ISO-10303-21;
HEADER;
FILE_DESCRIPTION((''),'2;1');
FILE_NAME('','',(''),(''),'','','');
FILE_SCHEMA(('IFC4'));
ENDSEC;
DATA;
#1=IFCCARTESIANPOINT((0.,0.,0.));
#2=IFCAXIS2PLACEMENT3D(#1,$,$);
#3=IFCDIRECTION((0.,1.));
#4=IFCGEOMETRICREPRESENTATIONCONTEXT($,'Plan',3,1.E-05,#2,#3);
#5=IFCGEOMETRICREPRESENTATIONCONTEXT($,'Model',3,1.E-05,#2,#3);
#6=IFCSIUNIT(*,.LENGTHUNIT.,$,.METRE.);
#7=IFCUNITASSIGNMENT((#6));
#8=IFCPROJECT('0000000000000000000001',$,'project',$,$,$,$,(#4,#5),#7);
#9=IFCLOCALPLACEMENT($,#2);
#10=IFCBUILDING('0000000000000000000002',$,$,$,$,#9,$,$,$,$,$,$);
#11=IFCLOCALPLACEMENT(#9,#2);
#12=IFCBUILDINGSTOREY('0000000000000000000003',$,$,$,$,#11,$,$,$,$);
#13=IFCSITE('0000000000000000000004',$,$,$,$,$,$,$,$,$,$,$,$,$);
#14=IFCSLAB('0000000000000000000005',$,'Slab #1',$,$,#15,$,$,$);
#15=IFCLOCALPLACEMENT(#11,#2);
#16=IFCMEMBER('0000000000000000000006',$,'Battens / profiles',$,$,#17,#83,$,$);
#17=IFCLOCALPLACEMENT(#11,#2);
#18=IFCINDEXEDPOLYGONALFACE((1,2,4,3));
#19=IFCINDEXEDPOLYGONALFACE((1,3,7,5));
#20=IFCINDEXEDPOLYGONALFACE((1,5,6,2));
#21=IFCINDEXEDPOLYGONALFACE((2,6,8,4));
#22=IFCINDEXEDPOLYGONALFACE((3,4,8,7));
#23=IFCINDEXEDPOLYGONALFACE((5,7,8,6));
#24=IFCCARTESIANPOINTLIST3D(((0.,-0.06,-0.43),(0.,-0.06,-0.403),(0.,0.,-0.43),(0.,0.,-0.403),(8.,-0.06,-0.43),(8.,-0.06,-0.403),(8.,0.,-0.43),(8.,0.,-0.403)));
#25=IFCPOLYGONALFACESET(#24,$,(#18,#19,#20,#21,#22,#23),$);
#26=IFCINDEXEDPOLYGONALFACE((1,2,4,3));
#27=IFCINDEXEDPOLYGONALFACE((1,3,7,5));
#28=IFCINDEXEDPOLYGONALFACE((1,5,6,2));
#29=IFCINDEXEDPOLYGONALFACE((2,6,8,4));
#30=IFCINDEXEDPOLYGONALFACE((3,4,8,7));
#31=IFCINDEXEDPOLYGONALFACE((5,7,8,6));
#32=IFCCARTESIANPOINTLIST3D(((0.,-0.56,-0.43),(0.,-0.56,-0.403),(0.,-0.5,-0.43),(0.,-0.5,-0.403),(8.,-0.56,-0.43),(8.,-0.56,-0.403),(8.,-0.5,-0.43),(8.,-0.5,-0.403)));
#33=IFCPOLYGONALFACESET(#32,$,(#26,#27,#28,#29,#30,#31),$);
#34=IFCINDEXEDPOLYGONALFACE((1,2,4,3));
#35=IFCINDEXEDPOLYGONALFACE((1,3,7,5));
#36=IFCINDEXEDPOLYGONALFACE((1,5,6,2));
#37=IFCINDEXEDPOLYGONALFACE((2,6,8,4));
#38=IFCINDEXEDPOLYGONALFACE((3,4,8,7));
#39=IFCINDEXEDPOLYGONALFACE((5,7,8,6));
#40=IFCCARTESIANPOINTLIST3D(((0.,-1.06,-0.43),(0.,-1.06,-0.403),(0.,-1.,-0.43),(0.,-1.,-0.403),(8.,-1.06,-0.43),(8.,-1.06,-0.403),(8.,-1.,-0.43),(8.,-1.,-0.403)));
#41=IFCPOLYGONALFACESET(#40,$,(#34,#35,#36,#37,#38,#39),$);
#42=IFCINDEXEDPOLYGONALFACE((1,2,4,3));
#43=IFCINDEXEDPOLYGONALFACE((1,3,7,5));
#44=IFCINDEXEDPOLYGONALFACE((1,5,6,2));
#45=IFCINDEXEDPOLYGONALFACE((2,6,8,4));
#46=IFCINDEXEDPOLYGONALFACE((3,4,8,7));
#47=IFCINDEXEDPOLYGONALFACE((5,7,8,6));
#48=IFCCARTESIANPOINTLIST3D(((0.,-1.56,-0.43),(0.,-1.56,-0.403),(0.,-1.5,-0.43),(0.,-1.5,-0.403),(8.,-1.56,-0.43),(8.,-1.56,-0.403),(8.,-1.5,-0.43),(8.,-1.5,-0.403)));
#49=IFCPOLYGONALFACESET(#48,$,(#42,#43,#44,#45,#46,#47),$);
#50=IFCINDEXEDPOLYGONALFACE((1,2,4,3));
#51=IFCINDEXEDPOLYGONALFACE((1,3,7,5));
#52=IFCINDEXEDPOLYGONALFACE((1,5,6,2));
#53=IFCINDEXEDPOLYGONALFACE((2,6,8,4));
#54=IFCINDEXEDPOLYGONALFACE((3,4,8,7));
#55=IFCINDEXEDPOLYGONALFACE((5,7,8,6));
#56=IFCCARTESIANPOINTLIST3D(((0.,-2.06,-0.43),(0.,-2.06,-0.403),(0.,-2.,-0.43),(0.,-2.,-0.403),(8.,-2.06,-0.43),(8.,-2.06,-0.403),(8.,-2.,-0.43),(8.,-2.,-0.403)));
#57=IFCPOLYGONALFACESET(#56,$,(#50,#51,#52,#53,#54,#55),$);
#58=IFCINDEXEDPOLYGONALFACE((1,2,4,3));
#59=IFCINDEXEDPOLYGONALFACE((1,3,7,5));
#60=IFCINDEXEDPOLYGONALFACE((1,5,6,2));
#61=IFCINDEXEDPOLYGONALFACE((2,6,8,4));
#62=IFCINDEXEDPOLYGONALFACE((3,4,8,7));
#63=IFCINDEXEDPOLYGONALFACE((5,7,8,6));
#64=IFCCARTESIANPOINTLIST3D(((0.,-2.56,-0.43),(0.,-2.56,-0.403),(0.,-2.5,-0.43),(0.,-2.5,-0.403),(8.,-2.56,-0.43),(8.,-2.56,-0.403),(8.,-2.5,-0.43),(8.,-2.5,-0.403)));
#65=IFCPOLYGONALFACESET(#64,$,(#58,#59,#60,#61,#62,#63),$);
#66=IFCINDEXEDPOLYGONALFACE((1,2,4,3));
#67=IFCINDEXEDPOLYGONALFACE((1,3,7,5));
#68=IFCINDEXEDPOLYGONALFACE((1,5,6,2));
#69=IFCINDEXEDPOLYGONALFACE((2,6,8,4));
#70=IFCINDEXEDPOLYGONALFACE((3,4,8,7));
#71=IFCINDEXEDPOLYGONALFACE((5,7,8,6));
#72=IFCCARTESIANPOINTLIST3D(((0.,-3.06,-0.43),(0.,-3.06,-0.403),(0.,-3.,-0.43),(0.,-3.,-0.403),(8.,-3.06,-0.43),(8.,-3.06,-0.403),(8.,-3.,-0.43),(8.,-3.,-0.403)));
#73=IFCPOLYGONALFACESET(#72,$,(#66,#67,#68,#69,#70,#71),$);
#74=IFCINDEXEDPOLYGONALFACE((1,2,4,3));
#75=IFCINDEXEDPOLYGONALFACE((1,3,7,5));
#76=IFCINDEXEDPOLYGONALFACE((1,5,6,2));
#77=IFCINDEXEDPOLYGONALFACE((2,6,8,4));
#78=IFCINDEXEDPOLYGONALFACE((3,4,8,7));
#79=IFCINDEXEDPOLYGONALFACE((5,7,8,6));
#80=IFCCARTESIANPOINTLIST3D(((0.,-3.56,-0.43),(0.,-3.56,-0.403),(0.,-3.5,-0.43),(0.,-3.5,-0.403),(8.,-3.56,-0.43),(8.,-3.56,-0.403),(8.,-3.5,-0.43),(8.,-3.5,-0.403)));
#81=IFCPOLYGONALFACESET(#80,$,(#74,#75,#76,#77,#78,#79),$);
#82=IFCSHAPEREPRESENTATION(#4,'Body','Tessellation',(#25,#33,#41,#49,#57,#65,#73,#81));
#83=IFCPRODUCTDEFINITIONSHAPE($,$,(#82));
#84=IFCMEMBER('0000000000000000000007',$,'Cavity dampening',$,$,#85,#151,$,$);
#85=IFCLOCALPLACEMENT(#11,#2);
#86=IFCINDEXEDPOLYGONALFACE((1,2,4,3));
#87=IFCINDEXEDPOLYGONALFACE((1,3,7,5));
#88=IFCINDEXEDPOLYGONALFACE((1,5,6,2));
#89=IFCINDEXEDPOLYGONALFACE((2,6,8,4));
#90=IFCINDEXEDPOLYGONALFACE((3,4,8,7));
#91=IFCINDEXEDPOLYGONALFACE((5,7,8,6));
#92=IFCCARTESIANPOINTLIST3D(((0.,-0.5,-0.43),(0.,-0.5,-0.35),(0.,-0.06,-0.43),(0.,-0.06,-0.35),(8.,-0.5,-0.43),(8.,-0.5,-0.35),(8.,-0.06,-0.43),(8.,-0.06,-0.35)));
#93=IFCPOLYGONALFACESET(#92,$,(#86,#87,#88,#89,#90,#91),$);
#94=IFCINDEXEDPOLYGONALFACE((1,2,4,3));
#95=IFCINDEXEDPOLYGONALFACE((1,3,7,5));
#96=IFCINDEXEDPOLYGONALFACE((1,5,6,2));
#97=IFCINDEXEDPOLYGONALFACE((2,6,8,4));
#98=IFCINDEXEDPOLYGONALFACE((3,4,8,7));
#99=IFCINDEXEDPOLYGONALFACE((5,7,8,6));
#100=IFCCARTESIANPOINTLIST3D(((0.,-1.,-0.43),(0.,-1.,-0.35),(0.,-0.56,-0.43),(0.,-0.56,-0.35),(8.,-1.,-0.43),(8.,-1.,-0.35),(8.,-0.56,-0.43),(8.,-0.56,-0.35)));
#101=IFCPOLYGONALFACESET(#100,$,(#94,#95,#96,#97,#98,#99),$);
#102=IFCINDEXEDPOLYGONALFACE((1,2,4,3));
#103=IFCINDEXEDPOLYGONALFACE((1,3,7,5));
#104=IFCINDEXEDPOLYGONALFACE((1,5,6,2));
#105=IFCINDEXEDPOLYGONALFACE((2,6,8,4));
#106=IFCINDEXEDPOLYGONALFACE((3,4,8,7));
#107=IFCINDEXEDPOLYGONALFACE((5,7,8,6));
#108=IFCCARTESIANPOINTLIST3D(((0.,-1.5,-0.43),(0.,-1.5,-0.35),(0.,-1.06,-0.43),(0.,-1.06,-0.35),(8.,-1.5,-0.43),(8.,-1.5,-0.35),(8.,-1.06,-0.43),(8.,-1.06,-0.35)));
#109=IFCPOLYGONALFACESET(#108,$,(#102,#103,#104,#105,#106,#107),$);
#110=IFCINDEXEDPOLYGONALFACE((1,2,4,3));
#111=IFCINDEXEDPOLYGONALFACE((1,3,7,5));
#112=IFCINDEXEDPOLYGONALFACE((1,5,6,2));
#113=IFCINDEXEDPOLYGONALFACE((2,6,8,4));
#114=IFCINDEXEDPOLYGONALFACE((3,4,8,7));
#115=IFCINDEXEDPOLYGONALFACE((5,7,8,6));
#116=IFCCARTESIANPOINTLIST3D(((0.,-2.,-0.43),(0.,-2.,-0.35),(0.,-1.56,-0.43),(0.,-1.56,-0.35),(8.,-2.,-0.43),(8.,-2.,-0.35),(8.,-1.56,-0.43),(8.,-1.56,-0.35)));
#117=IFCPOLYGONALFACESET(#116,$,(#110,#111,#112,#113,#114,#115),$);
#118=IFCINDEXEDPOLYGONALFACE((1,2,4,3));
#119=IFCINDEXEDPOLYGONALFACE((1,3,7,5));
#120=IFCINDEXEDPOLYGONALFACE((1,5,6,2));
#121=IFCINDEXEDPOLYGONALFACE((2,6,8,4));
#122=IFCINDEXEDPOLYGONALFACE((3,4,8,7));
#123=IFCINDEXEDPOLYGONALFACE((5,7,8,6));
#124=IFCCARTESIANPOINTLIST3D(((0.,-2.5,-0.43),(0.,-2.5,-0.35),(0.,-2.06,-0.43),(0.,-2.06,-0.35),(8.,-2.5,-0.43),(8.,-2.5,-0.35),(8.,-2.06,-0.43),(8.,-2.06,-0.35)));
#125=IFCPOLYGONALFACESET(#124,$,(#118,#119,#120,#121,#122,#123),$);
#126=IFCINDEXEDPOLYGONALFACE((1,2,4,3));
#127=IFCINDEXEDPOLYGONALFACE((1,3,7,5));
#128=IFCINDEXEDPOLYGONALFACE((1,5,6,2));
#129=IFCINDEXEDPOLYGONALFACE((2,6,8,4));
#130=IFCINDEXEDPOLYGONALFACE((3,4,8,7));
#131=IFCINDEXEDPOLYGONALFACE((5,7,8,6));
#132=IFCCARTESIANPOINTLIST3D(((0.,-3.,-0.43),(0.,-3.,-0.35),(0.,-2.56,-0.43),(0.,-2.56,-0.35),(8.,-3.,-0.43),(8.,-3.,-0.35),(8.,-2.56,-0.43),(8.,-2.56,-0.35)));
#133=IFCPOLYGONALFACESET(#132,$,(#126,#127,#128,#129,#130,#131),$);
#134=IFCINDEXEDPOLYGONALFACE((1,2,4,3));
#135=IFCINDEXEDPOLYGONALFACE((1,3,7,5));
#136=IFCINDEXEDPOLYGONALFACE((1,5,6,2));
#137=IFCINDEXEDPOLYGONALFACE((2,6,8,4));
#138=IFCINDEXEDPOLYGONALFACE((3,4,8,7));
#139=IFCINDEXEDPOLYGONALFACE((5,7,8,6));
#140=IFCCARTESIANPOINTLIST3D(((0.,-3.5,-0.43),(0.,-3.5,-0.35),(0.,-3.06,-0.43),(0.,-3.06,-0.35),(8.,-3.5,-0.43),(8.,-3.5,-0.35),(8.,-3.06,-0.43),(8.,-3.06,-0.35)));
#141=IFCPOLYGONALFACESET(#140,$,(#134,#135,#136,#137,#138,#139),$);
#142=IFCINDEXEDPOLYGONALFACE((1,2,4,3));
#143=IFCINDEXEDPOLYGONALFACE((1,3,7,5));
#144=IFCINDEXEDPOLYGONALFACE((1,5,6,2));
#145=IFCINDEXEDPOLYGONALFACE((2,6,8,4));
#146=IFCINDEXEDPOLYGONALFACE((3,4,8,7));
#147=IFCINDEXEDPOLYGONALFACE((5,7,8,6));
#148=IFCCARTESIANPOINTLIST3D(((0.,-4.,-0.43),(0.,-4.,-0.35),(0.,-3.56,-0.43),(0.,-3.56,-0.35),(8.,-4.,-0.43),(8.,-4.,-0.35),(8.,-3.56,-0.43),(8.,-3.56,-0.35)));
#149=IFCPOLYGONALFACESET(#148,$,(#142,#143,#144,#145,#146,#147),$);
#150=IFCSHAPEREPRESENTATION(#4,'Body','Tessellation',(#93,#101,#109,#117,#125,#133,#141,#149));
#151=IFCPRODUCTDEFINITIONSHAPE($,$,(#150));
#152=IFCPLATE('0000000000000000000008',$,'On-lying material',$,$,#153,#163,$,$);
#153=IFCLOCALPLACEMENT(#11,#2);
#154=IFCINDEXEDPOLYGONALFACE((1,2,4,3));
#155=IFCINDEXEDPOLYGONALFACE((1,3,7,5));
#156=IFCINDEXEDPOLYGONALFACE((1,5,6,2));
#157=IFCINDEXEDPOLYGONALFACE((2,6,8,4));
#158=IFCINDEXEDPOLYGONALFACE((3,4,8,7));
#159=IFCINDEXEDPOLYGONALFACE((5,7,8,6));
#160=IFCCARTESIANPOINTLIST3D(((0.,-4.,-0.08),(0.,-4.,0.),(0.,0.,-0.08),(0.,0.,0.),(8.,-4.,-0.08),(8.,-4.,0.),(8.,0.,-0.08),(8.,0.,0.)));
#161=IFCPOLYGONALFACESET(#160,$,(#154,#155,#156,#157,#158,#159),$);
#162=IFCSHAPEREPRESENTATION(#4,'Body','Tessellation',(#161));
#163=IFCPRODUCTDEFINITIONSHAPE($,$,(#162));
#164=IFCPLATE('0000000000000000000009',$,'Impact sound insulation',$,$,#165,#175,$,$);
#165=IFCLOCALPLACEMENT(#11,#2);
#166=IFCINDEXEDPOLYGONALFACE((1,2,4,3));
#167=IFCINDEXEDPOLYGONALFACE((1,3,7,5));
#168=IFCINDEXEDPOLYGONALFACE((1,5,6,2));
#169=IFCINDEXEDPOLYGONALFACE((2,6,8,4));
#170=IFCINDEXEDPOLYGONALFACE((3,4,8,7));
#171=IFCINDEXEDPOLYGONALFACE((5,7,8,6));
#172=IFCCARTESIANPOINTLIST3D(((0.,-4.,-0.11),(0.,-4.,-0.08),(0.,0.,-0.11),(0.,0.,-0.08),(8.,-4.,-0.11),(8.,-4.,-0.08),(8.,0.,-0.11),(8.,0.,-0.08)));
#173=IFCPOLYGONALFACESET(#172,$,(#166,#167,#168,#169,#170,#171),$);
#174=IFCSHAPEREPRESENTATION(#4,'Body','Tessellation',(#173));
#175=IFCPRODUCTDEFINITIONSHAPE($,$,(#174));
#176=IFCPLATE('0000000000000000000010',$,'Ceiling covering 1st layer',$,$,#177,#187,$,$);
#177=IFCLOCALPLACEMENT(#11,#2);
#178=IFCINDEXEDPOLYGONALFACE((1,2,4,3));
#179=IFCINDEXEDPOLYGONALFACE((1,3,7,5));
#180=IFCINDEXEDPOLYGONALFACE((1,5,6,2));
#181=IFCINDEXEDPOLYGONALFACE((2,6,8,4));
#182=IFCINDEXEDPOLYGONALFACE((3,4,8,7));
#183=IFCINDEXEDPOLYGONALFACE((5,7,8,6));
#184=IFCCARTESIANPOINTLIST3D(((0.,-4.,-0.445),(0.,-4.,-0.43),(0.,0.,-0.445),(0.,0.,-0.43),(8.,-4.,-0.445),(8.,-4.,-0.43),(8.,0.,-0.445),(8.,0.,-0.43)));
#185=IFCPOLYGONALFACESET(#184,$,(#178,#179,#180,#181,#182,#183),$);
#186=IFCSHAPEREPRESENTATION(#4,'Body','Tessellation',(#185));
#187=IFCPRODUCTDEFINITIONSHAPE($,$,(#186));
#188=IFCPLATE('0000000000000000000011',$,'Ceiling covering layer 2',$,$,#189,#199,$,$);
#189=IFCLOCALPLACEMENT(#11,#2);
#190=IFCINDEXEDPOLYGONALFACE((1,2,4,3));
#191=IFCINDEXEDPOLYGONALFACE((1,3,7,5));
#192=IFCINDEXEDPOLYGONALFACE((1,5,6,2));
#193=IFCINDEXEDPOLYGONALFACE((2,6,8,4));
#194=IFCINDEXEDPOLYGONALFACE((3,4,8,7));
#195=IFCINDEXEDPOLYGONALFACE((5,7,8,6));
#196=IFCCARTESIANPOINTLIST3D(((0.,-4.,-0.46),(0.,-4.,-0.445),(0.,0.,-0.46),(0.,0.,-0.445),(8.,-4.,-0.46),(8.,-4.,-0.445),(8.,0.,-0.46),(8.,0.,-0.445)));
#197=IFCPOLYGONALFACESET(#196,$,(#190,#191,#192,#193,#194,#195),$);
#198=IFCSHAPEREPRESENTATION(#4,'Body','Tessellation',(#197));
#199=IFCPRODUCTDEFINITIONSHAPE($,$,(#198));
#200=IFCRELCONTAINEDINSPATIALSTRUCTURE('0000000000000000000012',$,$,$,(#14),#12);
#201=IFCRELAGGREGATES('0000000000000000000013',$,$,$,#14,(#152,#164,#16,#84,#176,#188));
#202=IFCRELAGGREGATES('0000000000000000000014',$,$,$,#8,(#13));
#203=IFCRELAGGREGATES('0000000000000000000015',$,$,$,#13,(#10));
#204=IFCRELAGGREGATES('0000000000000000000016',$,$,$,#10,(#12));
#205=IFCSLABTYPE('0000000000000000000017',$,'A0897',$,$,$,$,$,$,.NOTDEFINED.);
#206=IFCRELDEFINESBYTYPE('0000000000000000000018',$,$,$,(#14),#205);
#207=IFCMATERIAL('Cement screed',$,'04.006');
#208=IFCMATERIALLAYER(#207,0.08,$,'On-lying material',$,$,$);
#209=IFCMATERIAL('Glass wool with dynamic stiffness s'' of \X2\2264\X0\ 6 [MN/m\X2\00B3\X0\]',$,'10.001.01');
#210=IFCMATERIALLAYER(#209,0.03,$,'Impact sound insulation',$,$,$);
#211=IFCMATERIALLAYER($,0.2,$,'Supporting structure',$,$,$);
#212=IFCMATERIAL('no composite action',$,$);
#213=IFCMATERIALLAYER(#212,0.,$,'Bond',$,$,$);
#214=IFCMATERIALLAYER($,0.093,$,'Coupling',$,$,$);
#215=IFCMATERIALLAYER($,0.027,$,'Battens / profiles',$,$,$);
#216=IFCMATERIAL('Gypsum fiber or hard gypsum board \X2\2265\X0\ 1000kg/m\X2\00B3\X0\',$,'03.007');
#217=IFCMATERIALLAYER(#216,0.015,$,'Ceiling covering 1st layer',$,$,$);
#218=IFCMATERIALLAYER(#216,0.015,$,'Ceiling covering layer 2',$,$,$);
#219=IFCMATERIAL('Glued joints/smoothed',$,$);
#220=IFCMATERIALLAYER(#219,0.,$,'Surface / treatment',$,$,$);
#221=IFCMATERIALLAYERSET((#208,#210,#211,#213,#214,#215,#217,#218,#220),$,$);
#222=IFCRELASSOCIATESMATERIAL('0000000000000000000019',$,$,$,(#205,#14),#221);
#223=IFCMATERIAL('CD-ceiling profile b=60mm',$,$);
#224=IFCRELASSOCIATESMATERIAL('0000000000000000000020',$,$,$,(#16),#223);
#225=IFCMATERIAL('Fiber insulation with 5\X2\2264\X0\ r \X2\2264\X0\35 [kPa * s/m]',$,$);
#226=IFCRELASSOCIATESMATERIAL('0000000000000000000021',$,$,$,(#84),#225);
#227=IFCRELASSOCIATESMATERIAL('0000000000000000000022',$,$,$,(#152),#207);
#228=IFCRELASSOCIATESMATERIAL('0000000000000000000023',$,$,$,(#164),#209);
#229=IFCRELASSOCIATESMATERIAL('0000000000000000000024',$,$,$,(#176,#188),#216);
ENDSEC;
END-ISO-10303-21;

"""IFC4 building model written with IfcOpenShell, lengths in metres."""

from ifc_helpers import new_model, si_unit, direction, frame, frame_2d, origin, origin_with_axes, place, context, project, spatial, rectangle, extrude, material, layer, layer_set, type_object, element, aggregate, save


model = new_model("IFC4")

# Units and contexts
plan_context = context("Plan", 3, precision=1e-05, world=origin(), true_north=direction((0.0, 1.0)))
model_context = context("Model", 3, precision=1e-05, world=origin(), true_north=direction((0.0, 1.0)))
ifc_project = project(units=[si_unit("LENGTHUNIT", "METRE")], contexts=[plan_context, model_context])

# Site, building, storey
site = spatial("IfcSite", under=ifc_project)
building_placement = place(None, origin())
building = spatial("IfcBuilding", under=site, at=building_placement)
storey_placement = place(building_placement, origin())
storey = spatial("IfcBuildingStorey", under=building, at=storey_placement)

# Slab, members, plates
ifc_material_1 = material(Name="Cement screed", Category="04.006")
ifc_layer_1 = layer(ifc_material_1, 0.08, Name="On-lying material")
ifc_material_2 = material(Name="Glass wool with dynamic stiffness s' of ≤ 6 [MN/m³]", Category="10.001.01")
ifc_layer_2 = layer(ifc_material_2, 0.03, Name="Impact sound insulation")
ifc_layer_3 = layer(None, 0.2, Name="Supporting structure")
ifc_material_3 = material(Name="no composite action")
ifc_layer_4 = layer(ifc_material_3, 0.0, Name="Bond")
ifc_layer_5 = layer(None, 0.093, Name="Coupling")
ifc_layer_6 = layer(None, 0.027, Name="Battens / profiles")
ifc_material_4 = material(Name="Gypsum fiber or hard gypsum board ≥ 1000kg/m³", Category="03.007")
ifc_layer_7 = layer(ifc_material_4, 0.015, Name="Ceiling covering 1st layer")
ifc_layer_8 = layer(ifc_material_4, 0.015, Name="Ceiling covering layer 2")
ifc_material_5 = material(Name="Glued joints/smoothed")
ifc_layer_9 = layer(ifc_material_5, 0.0, Name="Surface / treatment")
ifc_layer_set = layer_set([ifc_layer_1, ifc_layer_2, ifc_layer_3, ifc_layer_4, ifc_layer_5, ifc_layer_6, ifc_layer_7, ifc_layer_8, ifc_layer_9])
slab_type = type_object("IfcSlabType", Name="A0897", PredefinedType="NOTDEFINED", material=ifc_layer_set)
slab_placement = place(None, frame((0.0, 0.0, 0.0), z_axis=(0.0, 0.0, -1.0), x_axis=(1.0, 0.0, 0.0)))
slab = element("IfcSlab", 1, at=slab_placement, inside=storey, type_object=slab_type, material=ifc_layer_set, Name="Slab #1")
ifc_material_6 = material(Name="CD-ceiling profile b=60mm")
member_1_placement = place(slab_placement, origin())
member_1 = element("IfcMember", 2, at=member_1_placement, material=ifc_material_6, Name="Battens / profiles", context=plan_context, shape_type="SweptSolid", body=[
    extrude(rectangle(XDim=0.06, YDim=0.027, at=frame_2d((0.03, 0.0135), x_axis=(1.0, 0.0))), frame((0.0, 0.0, 0.403), z_axis=(1.0, 0.0, 0.0), x_axis=(0.0, 1.0, 0.0)), (0.0, 0.0, 1.0), 8.0),
    extrude(rectangle(XDim=0.06, YDim=0.027, at=frame_2d((0.03, 0.0135), x_axis=(1.0, 0.0))), frame((0.0, 0.5, 0.403), z_axis=(1.0, 0.0, 0.0), x_axis=(0.0, 1.0, 0.0)), (0.0, 0.0, 1.0), 8.0),
    extrude(rectangle(XDim=0.06, YDim=0.027, at=frame_2d((0.03, 0.0135), x_axis=(1.0, 0.0))), frame((0.0, 1.0, 0.403), z_axis=(1.0, 0.0, 0.0), x_axis=(0.0, 1.0, 0.0)), (0.0, 0.0, 1.0), 8.0),
    extrude(rectangle(XDim=0.06, YDim=0.027, at=frame_2d((0.03, 0.0135), x_axis=(1.0, 0.0))), frame((0.0, 1.5, 0.403), z_axis=(1.0, 0.0, 0.0), x_axis=(0.0, 1.0, 0.0)), (0.0, 0.0, 1.0), 8.0),
    extrude(rectangle(XDim=0.06, YDim=0.027, at=frame_2d((0.03, 0.0135), x_axis=(1.0, 0.0))), frame((0.0, 2.0, 0.403), z_axis=(1.0, 0.0, 0.0), x_axis=(0.0, 1.0, 0.0)), (0.0, 0.0, 1.0), 8.0),
    extrude(rectangle(XDim=0.06, YDim=0.027, at=frame_2d((0.03, 0.0135), x_axis=(1.0, 0.0))), frame((0.0, 2.5, 0.403), z_axis=(1.0, 0.0, 0.0), x_axis=(0.0, 1.0, 0.0)), (0.0, 0.0, 1.0), 8.0),
    extrude(rectangle(XDim=0.06, YDim=0.027, at=frame_2d((0.03, 0.0135), x_axis=(1.0, 0.0))), frame((0.0, 3.0, 0.403), z_axis=(1.0, 0.0, 0.0), x_axis=(0.0, 1.0, 0.0)), (0.0, 0.0, 1.0), 8.0),
    extrude(rectangle(XDim=0.06, YDim=0.027, at=frame_2d((0.03, 0.0135), x_axis=(1.0, 0.0))), frame((0.0, 3.5, 0.403), z_axis=(1.0, 0.0, 0.0), x_axis=(0.0, 1.0, 0.0)), (0.0, 0.0, 1.0), 8.0),
])
ifc_material_7 = material(Name="Fiber insulation with 5≤ r ≤35 [kPa * s/m]")
member_2_placement = place(slab_placement, origin())
member_2 = element("IfcMember", 3, at=member_2_placement, material=ifc_material_7, Name="Cavity dampening", context=plan_context, shape_type="SweptSolid", body=[
    extrude(rectangle(XDim=0.44, YDim=0.08, at=frame_2d((0.22, 0.04), x_axis=(1.0, 0.0))), frame((0.0, 0.06, 0.35), z_axis=(1.0, 0.0, 0.0), x_axis=(0.0, 1.0, 0.0)), (0.0, 0.0, 1.0), 8.0),
    extrude(rectangle(XDim=0.44, YDim=0.08, at=frame_2d((0.22, 0.04), x_axis=(1.0, 0.0))), frame((0.0, 0.56, 0.35), z_axis=(1.0, 0.0, 0.0), x_axis=(0.0, 1.0, 0.0)), (0.0, 0.0, 1.0), 8.0),
    extrude(rectangle(XDim=0.44, YDim=0.08, at=frame_2d((0.22, 0.04), x_axis=(1.0, 0.0))), frame((0.0, 1.06, 0.35), z_axis=(1.0, 0.0, 0.0), x_axis=(0.0, 1.0, 0.0)), (0.0, 0.0, 1.0), 8.0),
    extrude(rectangle(XDim=0.44, YDim=0.08, at=frame_2d((0.22, 0.04), x_axis=(1.0, 0.0))), frame((0.0, 1.56, 0.35), z_axis=(1.0, 0.0, 0.0), x_axis=(0.0, 1.0, 0.0)), (0.0, 0.0, 1.0), 8.0),
    extrude(rectangle(XDim=0.44, YDim=0.08, at=frame_2d((0.22, 0.04), x_axis=(1.0, 0.0))), frame((0.0, 2.06, 0.35), z_axis=(1.0, 0.0, 0.0), x_axis=(0.0, 1.0, 0.0)), (0.0, 0.0, 1.0), 8.0),
    extrude(rectangle(XDim=0.44, YDim=0.08, at=frame_2d((0.22, 0.04), x_axis=(1.0, 0.0))), frame((0.0, 2.56, 0.35), z_axis=(1.0, 0.0, 0.0), x_axis=(0.0, 1.0, 0.0)), (0.0, 0.0, 1.0), 8.0),
    extrude(rectangle(XDim=0.44, YDim=0.08, at=frame_2d((0.22, 0.04), x_axis=(1.0, 0.0))), frame((0.0, 3.06, 0.35), z_axis=(1.0, 0.0, 0.0), x_axis=(0.0, 1.0, 0.0)), (0.0, 0.0, 1.0), 8.0),
    extrude(rectangle(XDim=0.44, YDim=0.08, at=frame_2d((0.22, 0.04), x_axis=(1.0, 0.0))), frame((0.0, 3.56, 0.35), z_axis=(1.0, 0.0, 0.0), x_axis=(0.0, 1.0, 0.0)), (0.0, 0.0, 1.0), 8.0),
])
plate_1_placement = place(slab_placement, origin())
plate_1 = element("IfcPlate", 4, at=plate_1_placement, material=ifc_material_1, Name="On-lying material", context=plan_context, shape_type="SweptSolid", body=[
    extrude(rectangle(XDim=8.0, YDim=4.0, at=frame_2d((4.0, 2.0), x_axis=(1.0, 0.0))), origin_with_axes(), (0.0, 0.0, 1.0), 0.08),
])
plate_2_placement = place(slab_placement, origin())
plate_2 = element("IfcPlate", 5, at=plate_2_placement, material=ifc_material_2, Name="Impact sound insulation", context=plan_context, shape_type="SweptSolid", body=[
    extrude(rectangle(XDim=8.0, YDim=4.0, at=frame_2d((4.0, 2.0), x_axis=(1.0, 0.0))), frame((0.0, 0.0, 0.08), z_axis=(0.0, 0.0, 1.0), x_axis=(1.0, 0.0, 0.0)), (0.0, 0.0, 1.0), 0.03),
])
plate_3_placement = place(slab_placement, origin())
plate_3 = element("IfcPlate", 6, at=plate_3_placement, material=ifc_material_4, Name="Ceiling covering 1st layer", context=plan_context, shape_type="SweptSolid", body=[
    extrude(rectangle(XDim=8.0, YDim=4.0, at=frame_2d((4.0, 2.0), x_axis=(1.0, 0.0))), frame((0.0, 0.0, 0.43), z_axis=(0.0, 0.0, 1.0), x_axis=(1.0, 0.0, 0.0)), (0.0, 0.0, 1.0), 0.015),
])
plate_4_placement = place(slab_placement, origin())
plate_4 = element("IfcPlate", 7, at=plate_4_placement, material=ifc_material_4, Name="Ceiling covering layer 2", context=plan_context, shape_type="SweptSolid", body=[
    extrude(rectangle(XDim=8.0, YDim=4.0, at=frame_2d((4.0, 2.0), x_axis=(1.0, 0.0))), frame((0.0, 0.0, 0.445), z_axis=(0.0, 0.0, 1.0), x_axis=(1.0, 0.0, 0.0)), (0.0, 0.0, 1.0), 0.015),
])
aggregate(slab, [plate_1, plate_2, member_1, member_2, plate_3, plate_4])

save(model, "model.ifc")
